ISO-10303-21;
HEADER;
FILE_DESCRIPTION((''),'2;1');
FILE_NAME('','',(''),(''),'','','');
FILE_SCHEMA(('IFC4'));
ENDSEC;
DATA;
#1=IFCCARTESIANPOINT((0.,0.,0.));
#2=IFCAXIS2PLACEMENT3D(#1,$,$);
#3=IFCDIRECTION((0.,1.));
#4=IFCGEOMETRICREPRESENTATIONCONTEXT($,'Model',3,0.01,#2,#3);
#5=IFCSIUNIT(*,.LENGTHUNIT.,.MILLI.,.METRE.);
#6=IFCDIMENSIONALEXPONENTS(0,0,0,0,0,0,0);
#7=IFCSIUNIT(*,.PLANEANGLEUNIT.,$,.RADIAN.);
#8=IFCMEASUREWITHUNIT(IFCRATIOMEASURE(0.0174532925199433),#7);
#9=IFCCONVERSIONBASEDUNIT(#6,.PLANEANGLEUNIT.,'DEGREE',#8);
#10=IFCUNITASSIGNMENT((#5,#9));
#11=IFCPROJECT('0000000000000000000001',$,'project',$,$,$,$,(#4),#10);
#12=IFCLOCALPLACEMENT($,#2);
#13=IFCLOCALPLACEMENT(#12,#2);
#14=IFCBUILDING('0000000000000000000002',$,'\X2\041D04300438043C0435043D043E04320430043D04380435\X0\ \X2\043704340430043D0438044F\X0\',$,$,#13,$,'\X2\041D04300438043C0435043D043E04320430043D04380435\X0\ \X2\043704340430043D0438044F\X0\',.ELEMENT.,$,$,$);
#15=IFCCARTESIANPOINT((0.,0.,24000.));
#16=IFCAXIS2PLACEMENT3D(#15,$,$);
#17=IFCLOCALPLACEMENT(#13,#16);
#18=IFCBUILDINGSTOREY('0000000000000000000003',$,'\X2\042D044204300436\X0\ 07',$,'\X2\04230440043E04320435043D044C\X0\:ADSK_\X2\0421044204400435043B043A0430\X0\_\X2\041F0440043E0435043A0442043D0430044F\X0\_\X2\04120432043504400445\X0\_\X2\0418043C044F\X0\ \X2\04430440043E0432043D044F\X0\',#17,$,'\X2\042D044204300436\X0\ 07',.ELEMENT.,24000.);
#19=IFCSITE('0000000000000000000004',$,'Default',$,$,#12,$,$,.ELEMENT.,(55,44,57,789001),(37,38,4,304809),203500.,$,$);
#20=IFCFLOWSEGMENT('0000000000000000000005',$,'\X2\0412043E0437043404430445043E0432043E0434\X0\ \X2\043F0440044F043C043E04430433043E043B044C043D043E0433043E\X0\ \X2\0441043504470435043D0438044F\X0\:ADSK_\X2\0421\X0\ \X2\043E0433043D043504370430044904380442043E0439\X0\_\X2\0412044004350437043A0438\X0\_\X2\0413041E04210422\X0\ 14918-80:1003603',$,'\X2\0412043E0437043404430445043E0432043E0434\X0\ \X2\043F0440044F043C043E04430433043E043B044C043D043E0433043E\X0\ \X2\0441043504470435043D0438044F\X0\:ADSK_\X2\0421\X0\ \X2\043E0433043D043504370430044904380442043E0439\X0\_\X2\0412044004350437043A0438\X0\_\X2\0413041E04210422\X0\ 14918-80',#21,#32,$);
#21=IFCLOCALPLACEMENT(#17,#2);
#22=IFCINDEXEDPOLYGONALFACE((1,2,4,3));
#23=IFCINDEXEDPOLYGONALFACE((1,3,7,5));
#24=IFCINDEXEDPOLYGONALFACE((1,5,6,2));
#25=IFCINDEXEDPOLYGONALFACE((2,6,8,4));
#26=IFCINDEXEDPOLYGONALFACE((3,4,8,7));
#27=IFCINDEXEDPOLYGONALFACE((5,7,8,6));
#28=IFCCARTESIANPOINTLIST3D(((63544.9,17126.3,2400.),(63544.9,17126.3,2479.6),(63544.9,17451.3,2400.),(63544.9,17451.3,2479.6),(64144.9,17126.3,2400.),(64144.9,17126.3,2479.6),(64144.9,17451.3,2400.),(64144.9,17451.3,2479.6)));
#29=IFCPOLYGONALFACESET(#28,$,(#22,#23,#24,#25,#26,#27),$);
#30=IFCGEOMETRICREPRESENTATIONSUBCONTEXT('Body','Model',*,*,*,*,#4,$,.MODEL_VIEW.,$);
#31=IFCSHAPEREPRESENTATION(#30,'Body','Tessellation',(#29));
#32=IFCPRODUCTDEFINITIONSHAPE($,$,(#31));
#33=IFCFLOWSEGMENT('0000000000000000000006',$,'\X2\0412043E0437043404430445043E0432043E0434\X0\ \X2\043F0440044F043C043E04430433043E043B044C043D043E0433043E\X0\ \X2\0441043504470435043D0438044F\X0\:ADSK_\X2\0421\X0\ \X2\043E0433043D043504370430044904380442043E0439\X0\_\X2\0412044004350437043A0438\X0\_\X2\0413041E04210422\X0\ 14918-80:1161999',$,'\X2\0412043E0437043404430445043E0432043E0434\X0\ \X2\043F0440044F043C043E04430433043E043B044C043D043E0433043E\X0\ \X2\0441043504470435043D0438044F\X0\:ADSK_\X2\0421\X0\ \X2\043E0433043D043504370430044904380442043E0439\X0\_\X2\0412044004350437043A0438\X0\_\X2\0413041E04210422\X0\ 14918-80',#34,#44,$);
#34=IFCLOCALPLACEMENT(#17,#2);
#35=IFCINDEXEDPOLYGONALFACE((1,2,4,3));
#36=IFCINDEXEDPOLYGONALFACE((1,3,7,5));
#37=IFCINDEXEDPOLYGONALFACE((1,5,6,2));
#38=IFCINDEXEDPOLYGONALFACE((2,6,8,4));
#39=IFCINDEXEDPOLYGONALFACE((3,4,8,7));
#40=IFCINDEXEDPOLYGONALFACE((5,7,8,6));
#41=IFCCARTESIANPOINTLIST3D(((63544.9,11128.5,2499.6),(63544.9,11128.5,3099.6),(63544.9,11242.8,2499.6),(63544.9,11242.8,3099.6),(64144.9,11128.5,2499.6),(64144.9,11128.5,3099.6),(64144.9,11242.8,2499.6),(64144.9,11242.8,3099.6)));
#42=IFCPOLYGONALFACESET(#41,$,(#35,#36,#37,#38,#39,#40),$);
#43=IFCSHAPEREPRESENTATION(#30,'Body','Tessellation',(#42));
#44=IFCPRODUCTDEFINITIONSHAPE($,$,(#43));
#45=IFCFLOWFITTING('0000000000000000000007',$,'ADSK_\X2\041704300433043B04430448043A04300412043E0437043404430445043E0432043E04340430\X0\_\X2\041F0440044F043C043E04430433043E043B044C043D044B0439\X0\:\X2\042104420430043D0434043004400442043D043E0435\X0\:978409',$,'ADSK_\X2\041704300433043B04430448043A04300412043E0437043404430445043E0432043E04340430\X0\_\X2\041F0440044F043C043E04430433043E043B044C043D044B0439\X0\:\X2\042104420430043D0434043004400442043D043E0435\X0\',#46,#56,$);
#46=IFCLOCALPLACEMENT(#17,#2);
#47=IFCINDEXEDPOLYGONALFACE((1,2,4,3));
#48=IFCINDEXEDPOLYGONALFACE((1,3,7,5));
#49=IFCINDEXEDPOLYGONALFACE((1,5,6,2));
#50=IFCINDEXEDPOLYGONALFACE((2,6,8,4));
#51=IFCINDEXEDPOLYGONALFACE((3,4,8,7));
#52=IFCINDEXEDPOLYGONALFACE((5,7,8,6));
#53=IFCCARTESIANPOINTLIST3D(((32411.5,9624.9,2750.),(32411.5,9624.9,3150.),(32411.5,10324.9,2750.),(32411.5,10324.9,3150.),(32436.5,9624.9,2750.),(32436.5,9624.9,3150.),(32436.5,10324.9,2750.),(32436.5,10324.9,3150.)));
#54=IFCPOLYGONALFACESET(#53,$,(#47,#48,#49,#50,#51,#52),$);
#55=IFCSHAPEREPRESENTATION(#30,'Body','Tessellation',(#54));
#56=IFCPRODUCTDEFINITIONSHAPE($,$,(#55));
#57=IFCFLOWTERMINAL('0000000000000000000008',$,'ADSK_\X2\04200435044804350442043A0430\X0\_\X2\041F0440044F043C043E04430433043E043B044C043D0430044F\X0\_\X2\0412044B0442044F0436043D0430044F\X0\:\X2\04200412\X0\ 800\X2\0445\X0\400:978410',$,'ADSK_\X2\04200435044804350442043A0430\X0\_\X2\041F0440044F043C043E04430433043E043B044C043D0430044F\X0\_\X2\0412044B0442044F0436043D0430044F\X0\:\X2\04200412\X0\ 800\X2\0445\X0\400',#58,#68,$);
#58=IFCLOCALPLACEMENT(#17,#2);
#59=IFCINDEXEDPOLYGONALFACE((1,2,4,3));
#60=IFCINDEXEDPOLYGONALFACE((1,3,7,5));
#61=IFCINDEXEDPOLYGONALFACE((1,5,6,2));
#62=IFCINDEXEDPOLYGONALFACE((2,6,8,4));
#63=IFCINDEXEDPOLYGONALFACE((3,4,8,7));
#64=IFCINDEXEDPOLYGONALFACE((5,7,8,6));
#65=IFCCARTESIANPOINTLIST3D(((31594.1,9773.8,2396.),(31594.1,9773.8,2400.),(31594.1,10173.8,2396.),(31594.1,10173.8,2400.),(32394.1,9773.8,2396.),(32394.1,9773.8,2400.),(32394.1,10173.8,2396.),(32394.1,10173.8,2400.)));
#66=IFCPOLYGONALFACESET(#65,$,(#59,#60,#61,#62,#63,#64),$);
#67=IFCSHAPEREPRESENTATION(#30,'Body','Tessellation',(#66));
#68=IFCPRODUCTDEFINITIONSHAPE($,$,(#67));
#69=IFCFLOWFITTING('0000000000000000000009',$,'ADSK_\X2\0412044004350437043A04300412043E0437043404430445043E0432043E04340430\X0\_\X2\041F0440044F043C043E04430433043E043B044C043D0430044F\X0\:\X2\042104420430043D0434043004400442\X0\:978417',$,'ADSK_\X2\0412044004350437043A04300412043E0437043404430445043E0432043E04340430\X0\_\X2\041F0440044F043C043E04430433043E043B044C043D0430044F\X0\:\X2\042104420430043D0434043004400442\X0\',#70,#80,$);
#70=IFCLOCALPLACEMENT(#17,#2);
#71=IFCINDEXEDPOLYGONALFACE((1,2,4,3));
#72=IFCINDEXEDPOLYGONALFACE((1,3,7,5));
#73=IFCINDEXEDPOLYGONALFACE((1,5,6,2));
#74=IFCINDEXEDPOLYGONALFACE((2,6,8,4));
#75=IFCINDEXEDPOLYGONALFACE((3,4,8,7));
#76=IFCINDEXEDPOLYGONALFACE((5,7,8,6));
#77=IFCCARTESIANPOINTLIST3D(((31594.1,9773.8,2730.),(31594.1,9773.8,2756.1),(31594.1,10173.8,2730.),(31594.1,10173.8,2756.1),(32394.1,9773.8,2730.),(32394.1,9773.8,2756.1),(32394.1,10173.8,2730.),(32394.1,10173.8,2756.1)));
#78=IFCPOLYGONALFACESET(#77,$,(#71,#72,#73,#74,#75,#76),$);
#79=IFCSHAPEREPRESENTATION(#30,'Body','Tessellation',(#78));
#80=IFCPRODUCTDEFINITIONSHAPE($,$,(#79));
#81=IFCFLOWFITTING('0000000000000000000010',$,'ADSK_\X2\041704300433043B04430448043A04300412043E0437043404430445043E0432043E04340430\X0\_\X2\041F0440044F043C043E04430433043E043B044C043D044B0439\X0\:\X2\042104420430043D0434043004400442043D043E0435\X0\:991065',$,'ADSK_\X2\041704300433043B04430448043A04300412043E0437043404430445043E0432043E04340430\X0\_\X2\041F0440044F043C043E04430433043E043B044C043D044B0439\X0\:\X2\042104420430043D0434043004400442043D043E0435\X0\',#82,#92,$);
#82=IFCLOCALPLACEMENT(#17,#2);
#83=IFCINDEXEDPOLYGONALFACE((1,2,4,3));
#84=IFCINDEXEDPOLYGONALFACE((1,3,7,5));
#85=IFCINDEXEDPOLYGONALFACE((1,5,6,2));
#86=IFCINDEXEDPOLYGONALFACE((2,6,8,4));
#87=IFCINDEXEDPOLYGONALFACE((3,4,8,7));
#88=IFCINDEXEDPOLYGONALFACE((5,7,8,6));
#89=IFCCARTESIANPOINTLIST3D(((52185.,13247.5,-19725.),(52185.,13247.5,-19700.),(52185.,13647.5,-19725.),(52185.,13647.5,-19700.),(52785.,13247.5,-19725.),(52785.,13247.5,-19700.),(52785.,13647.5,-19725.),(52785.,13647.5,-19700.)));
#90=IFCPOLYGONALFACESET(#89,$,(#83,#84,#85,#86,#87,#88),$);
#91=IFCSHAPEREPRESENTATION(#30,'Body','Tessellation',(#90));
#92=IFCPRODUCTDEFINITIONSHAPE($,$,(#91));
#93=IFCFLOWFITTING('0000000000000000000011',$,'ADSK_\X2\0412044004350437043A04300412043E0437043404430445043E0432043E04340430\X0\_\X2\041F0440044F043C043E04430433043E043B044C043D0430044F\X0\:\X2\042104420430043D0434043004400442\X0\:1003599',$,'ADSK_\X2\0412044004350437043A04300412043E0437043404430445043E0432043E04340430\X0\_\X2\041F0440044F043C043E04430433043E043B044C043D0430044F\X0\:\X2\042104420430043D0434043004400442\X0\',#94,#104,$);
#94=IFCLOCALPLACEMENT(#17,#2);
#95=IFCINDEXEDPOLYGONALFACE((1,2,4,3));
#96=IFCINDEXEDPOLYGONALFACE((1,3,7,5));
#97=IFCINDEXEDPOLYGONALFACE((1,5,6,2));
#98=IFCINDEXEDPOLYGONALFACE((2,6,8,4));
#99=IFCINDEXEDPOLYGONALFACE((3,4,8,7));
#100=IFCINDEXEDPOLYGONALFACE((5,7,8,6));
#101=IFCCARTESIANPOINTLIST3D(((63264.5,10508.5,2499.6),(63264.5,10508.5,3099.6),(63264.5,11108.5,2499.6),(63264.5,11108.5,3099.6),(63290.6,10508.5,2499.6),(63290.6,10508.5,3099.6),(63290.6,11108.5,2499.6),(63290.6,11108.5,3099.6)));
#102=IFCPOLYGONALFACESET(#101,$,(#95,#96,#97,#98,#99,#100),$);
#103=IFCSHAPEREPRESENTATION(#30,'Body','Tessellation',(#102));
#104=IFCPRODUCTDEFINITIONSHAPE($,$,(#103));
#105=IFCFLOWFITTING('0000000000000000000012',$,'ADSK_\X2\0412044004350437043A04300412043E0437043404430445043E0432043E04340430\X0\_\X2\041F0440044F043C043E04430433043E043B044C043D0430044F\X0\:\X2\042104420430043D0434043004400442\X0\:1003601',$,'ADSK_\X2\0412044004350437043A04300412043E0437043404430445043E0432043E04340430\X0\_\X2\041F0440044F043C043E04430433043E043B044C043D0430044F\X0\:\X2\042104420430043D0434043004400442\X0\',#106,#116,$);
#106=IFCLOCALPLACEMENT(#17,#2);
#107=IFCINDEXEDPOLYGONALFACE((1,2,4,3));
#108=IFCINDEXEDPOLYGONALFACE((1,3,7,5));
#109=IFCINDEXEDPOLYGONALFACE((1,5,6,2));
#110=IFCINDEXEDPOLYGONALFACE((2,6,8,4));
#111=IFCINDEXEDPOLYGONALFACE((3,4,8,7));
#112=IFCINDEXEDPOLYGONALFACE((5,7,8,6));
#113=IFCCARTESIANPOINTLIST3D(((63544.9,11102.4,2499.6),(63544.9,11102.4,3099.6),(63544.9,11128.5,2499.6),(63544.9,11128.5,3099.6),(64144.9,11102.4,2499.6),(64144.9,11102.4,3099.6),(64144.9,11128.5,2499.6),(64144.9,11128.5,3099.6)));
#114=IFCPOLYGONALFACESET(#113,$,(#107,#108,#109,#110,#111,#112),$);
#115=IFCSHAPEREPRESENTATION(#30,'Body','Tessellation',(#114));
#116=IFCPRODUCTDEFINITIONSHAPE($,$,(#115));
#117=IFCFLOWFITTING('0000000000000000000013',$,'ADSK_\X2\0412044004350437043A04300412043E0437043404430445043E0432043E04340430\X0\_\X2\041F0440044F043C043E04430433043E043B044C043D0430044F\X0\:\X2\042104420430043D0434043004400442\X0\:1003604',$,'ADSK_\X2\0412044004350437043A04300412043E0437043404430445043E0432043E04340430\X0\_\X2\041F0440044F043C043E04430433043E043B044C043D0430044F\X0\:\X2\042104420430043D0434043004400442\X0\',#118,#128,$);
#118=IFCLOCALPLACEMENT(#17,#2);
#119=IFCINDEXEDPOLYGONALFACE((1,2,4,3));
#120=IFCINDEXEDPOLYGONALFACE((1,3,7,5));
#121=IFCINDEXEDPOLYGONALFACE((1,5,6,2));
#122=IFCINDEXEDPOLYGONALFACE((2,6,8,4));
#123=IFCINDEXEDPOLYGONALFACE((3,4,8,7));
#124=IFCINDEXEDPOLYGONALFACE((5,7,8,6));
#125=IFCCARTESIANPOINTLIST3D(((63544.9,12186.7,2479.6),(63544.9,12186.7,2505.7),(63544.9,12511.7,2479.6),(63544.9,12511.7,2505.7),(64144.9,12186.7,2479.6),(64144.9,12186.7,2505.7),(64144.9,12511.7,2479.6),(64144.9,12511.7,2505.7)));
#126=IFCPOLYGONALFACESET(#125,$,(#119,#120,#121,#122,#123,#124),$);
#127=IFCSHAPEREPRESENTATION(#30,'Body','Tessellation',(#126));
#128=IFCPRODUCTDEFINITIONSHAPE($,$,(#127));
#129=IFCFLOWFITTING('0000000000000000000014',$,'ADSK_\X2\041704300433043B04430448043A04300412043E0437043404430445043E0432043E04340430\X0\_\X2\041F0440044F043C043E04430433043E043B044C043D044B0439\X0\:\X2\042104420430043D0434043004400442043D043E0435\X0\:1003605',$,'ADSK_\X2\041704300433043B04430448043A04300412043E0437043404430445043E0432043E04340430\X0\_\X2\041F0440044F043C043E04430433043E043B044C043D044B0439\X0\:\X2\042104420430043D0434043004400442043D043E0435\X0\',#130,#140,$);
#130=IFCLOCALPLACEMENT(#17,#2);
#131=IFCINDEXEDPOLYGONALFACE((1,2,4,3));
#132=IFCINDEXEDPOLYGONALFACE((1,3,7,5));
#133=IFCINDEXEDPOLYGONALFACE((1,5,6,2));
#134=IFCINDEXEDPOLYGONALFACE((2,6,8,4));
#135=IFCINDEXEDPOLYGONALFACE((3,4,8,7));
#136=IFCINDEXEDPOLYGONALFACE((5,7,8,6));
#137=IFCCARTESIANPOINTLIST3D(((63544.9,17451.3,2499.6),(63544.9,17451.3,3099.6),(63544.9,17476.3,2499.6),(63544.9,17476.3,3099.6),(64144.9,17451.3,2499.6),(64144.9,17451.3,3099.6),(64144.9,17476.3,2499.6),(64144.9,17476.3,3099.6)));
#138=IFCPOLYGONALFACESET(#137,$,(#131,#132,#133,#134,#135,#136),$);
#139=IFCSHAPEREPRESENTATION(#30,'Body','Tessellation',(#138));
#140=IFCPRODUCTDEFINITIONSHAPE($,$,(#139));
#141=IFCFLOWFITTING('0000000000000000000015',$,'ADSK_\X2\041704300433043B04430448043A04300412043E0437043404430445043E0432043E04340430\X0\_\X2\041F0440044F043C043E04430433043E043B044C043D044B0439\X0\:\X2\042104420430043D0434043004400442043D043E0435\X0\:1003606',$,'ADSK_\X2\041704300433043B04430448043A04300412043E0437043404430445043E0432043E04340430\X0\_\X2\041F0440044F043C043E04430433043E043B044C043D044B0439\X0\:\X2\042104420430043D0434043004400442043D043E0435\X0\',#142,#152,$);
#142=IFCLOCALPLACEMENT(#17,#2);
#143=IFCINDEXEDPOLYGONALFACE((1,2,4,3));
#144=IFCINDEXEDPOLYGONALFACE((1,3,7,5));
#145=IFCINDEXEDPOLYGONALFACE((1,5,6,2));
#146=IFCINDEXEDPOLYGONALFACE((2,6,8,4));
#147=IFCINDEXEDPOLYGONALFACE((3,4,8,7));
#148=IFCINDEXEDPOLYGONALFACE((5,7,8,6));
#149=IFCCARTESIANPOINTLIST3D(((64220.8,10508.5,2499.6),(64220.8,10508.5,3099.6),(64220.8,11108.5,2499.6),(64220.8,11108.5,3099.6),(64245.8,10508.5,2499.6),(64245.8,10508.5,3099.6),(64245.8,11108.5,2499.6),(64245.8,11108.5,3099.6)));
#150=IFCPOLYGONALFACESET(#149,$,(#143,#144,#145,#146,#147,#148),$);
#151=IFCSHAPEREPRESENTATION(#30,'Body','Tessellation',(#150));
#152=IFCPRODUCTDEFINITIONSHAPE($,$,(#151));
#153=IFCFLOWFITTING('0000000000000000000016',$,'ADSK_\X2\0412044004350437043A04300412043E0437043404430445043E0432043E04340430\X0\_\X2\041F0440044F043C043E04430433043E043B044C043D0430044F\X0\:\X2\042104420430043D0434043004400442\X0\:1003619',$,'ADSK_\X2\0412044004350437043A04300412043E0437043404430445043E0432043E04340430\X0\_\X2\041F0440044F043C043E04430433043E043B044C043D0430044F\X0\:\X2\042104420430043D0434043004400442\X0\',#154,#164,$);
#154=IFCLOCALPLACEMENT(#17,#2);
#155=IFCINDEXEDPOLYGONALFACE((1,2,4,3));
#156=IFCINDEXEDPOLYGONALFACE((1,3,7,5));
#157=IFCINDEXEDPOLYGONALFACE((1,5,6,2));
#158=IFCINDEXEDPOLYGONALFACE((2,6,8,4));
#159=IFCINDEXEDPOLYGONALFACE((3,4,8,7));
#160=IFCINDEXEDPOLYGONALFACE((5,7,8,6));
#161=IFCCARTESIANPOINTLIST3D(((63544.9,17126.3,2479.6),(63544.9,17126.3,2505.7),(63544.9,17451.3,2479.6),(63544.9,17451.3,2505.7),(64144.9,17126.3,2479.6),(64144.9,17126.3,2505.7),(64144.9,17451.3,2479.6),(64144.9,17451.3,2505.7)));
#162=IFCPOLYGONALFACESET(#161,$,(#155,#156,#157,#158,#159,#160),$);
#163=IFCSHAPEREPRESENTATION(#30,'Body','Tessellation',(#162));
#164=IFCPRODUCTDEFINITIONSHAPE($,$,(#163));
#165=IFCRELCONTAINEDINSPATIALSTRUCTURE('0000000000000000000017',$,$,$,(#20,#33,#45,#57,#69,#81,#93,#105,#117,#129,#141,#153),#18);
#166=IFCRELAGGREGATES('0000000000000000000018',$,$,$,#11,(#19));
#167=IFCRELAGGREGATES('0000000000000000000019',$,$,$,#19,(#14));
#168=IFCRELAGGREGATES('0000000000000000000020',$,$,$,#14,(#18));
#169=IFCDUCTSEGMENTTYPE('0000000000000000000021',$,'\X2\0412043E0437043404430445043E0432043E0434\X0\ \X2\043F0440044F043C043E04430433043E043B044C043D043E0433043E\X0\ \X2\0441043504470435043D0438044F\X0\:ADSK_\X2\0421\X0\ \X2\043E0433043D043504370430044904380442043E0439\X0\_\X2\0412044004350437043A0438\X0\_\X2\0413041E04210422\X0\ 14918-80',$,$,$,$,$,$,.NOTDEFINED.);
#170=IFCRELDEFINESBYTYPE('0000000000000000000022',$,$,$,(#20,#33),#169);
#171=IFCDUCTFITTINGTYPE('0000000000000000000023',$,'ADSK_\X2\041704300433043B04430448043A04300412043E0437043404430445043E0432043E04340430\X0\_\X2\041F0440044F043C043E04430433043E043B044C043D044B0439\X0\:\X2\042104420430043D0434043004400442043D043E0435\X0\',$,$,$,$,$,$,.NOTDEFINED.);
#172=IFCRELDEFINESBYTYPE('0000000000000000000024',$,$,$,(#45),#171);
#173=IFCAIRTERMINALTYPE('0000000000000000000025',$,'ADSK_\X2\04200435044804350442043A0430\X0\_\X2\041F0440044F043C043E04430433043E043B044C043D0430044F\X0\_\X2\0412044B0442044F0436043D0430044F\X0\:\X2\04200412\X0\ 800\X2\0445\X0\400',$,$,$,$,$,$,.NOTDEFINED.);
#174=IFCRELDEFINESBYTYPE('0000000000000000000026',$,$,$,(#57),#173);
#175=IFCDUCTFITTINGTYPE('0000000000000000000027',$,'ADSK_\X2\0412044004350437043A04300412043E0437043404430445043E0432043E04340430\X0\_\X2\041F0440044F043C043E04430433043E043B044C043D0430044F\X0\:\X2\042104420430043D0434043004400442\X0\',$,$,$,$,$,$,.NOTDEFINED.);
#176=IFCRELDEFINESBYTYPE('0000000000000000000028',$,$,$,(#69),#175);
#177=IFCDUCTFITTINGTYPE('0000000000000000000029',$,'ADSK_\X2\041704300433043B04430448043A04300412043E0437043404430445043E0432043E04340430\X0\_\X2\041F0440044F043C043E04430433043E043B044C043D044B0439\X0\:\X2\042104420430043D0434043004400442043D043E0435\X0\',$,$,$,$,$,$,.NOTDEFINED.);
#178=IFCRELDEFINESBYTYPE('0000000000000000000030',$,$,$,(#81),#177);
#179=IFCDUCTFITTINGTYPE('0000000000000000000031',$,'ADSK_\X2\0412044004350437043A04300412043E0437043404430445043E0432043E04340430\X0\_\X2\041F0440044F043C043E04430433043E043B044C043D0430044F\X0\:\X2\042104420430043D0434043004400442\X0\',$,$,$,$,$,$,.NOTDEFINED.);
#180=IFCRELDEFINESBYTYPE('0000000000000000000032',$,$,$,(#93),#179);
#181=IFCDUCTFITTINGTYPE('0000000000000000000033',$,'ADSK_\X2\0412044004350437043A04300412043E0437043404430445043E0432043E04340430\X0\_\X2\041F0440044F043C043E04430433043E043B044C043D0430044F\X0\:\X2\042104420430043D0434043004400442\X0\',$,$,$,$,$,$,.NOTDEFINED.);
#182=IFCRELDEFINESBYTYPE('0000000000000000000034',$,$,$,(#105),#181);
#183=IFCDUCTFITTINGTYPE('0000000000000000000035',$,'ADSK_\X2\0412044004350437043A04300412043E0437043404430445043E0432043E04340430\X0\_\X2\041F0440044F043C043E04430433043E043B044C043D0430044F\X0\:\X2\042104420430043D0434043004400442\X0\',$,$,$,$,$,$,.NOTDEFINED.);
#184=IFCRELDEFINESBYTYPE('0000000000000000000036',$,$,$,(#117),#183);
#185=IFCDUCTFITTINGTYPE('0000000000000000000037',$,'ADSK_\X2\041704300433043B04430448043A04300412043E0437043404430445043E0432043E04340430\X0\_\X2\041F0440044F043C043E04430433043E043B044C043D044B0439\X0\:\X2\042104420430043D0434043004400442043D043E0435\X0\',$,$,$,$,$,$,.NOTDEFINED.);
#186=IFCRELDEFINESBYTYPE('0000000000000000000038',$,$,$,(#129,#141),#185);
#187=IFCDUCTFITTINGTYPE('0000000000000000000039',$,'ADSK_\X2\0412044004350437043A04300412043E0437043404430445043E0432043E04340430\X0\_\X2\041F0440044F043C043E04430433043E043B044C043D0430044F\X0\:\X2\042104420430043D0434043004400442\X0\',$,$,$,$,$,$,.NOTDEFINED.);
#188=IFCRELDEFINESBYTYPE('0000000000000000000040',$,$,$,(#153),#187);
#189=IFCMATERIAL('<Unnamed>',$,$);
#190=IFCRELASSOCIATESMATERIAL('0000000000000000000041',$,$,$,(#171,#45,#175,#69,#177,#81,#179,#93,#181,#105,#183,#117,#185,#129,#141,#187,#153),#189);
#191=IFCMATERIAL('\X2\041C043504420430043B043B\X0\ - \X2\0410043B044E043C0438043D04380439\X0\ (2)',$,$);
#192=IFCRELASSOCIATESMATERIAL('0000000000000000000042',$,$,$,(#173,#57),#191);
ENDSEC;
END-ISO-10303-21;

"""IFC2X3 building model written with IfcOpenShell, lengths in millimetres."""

from ifc_helpers import new_model, entity, si_unit, converted_unit, direction, frame, frame_2d, origin, origin_2d_with_axis, place, context, subcontext, project, spatial, rectangle, extrude, source, transform, mapped, material, type_object, type_shapes, element, save


model = new_model("IFC2X3")

# Units and contexts
model_context = context("Model", 3, precision=0.01, world=origin(), true_north=direction((0.0, 1.0)))
body_context = subcontext(model_context, "Body", "Model", "MODEL_VIEW")
ifc_project = project(units=[si_unit("LENGTHUNIT", "METRE", prefix="MILLI"), converted_unit("PLANEANGLEUNIT", "DEGREE", entity("IfcRatioMeasure", 0.0174532925199433), si_unit("PLANEANGLEUNIT", "RADIAN"), dimensions=[0, 0, 0, 0, 0, 0, 0])], contexts=[model_context])

# Site, building, storey
site_placement = place(None, frame((0.0, 0.0, 0.0)))
site = spatial("IfcSite", under=ifc_project, at=site_placement, Name="Default", CompositionType="ELEMENT", RefLatitude=(55, 44, 57, 789001), RefLongitude=(37, 38, 4, 304809), RefElevation=203500.0)
building_placement = place(site_placement, origin())
building = spatial("IfcBuilding", under=site, at=building_placement, Name="Наименование здания", LongName="Наименование здания", CompositionType="ELEMENT")
storey_placement = place(building_placement, frame((0.0, 0.0, 24000.0)))
storey = spatial("IfcBuildingStorey", under=building, at=storey_placement, Name="Этаж 07", ObjectType="Уровень:ADSK_Стрелка_Проектная_Вверх_Имя уровня", LongName="Этаж 07", CompositionType="ELEMENT", Elevation=24000.0)

# Flow segments
duct_segment_type_1 = type_object("IfcDuctSegmentType", Name="Воздуховод прямоугольного сечения:ADSK_С огнезащитой_Врезки_ГОСТ 14918-80", PredefinedType="NOTDEFINED")
flow_segment_1_placement = place(storey_placement, frame((63544.9, 17126.3, 2400.0)))
element("IfcFlowSegment", 1, at=flow_segment_1_placement, inside=storey, type_object=duct_segment_type_1, Name="Воздуховод прямоугольного сечения:ADSK_С огнезащитой_Врезки_ГОСТ 14918-80:1003603", ObjectType="Воздуховод прямоугольного сечения:ADSK_С огнезащитой_Врезки_ГОСТ 14918-80", context=body_context, shape_type="SweptSolid", body=[
    extrude(rectangle(XDim=600.0, YDim=325.0, at=frame_2d((0.0, 0.0), x_axis=(1.0, 0.0))), frame((300.0, 162.5, 0.0), z_axis=(0.0, 0.0, 1.0), x_axis=(-1.0, 0.0, 0.0)), (0.0, 0.0, 1.0), 79.6),
])
flow_segment_2_placement = place(storey_placement, frame((63544.9, 11128.5, 2499.6)))
element("IfcFlowSegment", 2, at=flow_segment_2_placement, inside=storey, type_object=duct_segment_type_1, Name="Воздуховод прямоугольного сечения:ADSK_С огнезащитой_Врезки_ГОСТ 14918-80:1161999", ObjectType="Воздуховод прямоугольного сечения:ADSK_С огнезащитой_Врезки_ГОСТ 14918-80", context=body_context, shape_type="SweptSolid", body=[
    extrude(rectangle(XDim=114.3, YDim=600.0, at=origin_2d_with_axis()), frame((300.0, 57.1, 0.0), z_axis=(0.0, 0.0, 1.0), x_axis=(0.0, 1.0, 0.0)), (0.0, 0.0, 1.0), 600.0),
])

# Flow fitting
ifc_material_1 = material(Name="<Unnamed>")
duct_fitting_type_1 = type_object("IfcDuctFittingType", Name="ADSK_ЗаглушкаВоздуховода_Прямоугольный:Стандартное", PredefinedType="NOTDEFINED", material=ifc_material_1)
shared_shape_1 = source(origin(), body_context, "Body", "SweptSolid", [
    extrude(rectangle(XDim=25.0, YDim=700.0, at=frame_2d((0.0, 0.0), x_axis=(1.0, 0.0))), frame((12.5, 0.0, -200.0)), (0.0, 0.0, 1.0), 400.0),
])
type_shapes(duct_fitting_type_1, [shared_shape_1])
flow_fitting_1_placement = place(storey_placement, frame((32411.5, 9974.9, 2950.0)))
element("IfcFlowFitting", 3, at=flow_fitting_1_placement, inside=storey, type_object=duct_fitting_type_1, material=ifc_material_1, Name="ADSK_ЗаглушкаВоздуховода_Прямоугольный:Стандартное:978409", ObjectType="ADSK_ЗаглушкаВоздуховода_Прямоугольный:Стандартное", context=body_context, shape_type="MappedRepresentation", body=[
    mapped(shared_shape_1, transform((0.0, 0.0, 0.0), scale=1.0)),
])

# Flow terminal
ifc_material_2 = material(Name="Металл - Алюминий (2)")
air_terminal_type_1 = type_object("IfcAirTerminalType", Name="ADSK_Решетка_Прямоугольная_Вытяжная:РВ 800х400", PredefinedType="NOTDEFINED", material=ifc_material_2)
shared_shape_2 = source(origin(), body_context, "Body", "SweptSolid", [
    extrude(rectangle(XDim=4.0, YDim=800.0, at=origin_2d_with_axis()), frame((0.0, -2.0, -200.0), z_axis=(0.0, 0.0, 1.0), x_axis=(0.0, 1.0, 0.0)), (0.0, 0.0, 1.0), 400.0),
])
type_shapes(air_terminal_type_1, [shared_shape_2])
flow_terminal_1_placement = place(storey_placement, frame((31994.1, 9973.8, 2400.0), z_axis=(0.0, 1.0, 0.0), x_axis=(-1.0, 0.0, 0.0)))
element("IfcFlowTerminal", 4, at=flow_terminal_1_placement, inside=storey, type_object=air_terminal_type_1, material=ifc_material_2, Name="ADSK_Решетка_Прямоугольная_Вытяжная:РВ 800х400:978410", ObjectType="ADSK_Решетка_Прямоугольная_Вытяжная:РВ 800х400", context=body_context, shape_type="MappedRepresentation", body=[
    mapped(shared_shape_2, transform((0.0, 0.0, 0.0), scale=1.0)),
])

# Flow fittings
duct_fitting_type_2 = type_object("IfcDuctFittingType", Name="ADSK_ВрезкаВоздуховода_Прямоугольная:Стандарт", PredefinedType="NOTDEFINED", material=ifc_material_1)
shared_shape_3 = source(origin(), body_context, "Body", "SweptSolid", [
    extrude(rectangle(XDim=26.1, YDim=800.0, at=frame_2d((0.0, 0.0), x_axis=(1.0, 0.0))), frame((7.0, 0.0, -200.0)), (0.0, 0.0, 1.0), 400.0),
])
type_shapes(duct_fitting_type_2, [shared_shape_3])
flow_fitting_2_placement = place(storey_placement, frame((31994.1, 9973.8, 2750.0), z_axis=(0.0, 1.0, 0.0), x_axis=(0.0, 0.0, -1.0)))
element("IfcFlowFitting", 5, at=flow_fitting_2_placement, inside=storey, type_object=duct_fitting_type_2, material=ifc_material_1, Name="ADSK_ВрезкаВоздуховода_Прямоугольная:Стандарт:978417", ObjectType="ADSK_ВрезкаВоздуховода_Прямоугольная:Стандарт", context=body_context, shape_type="MappedRepresentation", body=[
    mapped(shared_shape_3, transform((0.0, 0.0, 0.0), scale=1.0)),
])
duct_fitting_type_3 = type_object("IfcDuctFittingType", Name="ADSK_ЗаглушкаВоздуховода_Прямоугольный:Стандартное", PredefinedType="NOTDEFINED", material=ifc_material_1)
shared_shape_4 = source(origin(), body_context, "Body", "SweptSolid", [
    extrude(rectangle(XDim=25.0, YDim=600.0, at=frame_2d((0.0, 0.0), x_axis=(1.0, 0.0))), frame((12.5, 0.0, -200.0)), (0.0, 0.0, 1.0), 400.0),
])
type_shapes(duct_fitting_type_3, [shared_shape_4])
flow_fitting_3_placement = place(storey_placement, frame((52485.0, 13447.5, -19700.0), z_axis=(0.0, -1.0, 0.0), x_axis=(0.0, 0.0, -1.0)))
element("IfcFlowFitting", 6, at=flow_fitting_3_placement, inside=storey, type_object=duct_fitting_type_3, material=ifc_material_1, Name="ADSK_ЗаглушкаВоздуховода_Прямоугольный:Стандартное:991065", ObjectType="ADSK_ЗаглушкаВоздуховода_Прямоугольный:Стандартное", context=body_context, shape_type="MappedRepresentation", body=[
    mapped(shared_shape_4, transform((0.0, 0.0, 0.0), scale=1.0)),
])
duct_fitting_type_4 = type_object("IfcDuctFittingType", Name="ADSK_ВрезкаВоздуховода_Прямоугольная:Стандарт", PredefinedType="NOTDEFINED", material=ifc_material_1)
shared_shape_5 = source(origin(), body_context, "Body", "SweptSolid", [
    extrude(rectangle(XDim=26.1, YDim=600.0, at=frame_2d((0.0, 0.0), x_axis=(1.0, 0.0))), frame((7.0, 0.0, -300.0)), (0.0, 0.0, 1.0), 600.0),
])
type_shapes(duct_fitting_type_4, [shared_shape_5])
flow_fitting_4_placement = place(storey_placement, frame((63270.6, 10808.5, 2799.6), z_axis=(0.0, -1.0, 0.0), x_axis=(1.0, 0.0, 0.0)))
element("IfcFlowFitting", 7, at=flow_fitting_4_placement, inside=storey, type_object=duct_fitting_type_4, material=ifc_material_1, Name="ADSK_ВрезкаВоздуховода_Прямоугольная:Стандарт:1003599", ObjectType="ADSK_ВрезкаВоздуховода_Прямоугольная:Стандарт", context=body_context, shape_type="MappedRepresentation", body=[
    mapped(shared_shape_5, transform((0.0, 0.0, 0.0), scale=1.0)),
])
duct_fitting_type_5 = type_object("IfcDuctFittingType", Name="ADSK_ВрезкаВоздуховода_Прямоугольная:Стандарт", PredefinedType="NOTDEFINED", material=ifc_material_1)
shared_shape_6 = source(origin(), body_context, "Body", "SweptSolid", [
    extrude(rectangle(XDim=600.0, YDim=26.1, at=origin_2d_with_axis()), frame((7.0, 0.0, -300.0), z_axis=(0.0, 0.0, 1.0), x_axis=(0.0, -1.0, 0.0)), (0.0, 0.0, 1.0), 600.0),
])
type_shapes(duct_fitting_type_5, [shared_shape_6])
flow_fitting_5_placement = place(storey_placement, frame((63844.9, 11108.5, 2799.6), z_axis=(0.0, 0.0, -1.0), x_axis=(0.0, 1.0, 0.0)))
element("IfcFlowFitting", 8, at=flow_fitting_5_placement, inside=storey, type_object=duct_fitting_type_5, material=ifc_material_1, Name="ADSK_ВрезкаВоздуховода_Прямоугольная:Стандарт:1003601", ObjectType="ADSK_ВрезкаВоздуховода_Прямоугольная:Стандарт", context=body_context, shape_type="MappedRepresentation", body=[
    mapped(shared_shape_6, transform((0.0, 0.0, 0.0), scale=1.0)),
])
duct_fitting_type_6 = type_object("IfcDuctFittingType", Name="ADSK_ВрезкаВоздуховода_Прямоугольная:Стандарт", PredefinedType="NOTDEFINED", material=ifc_material_1)
shared_shape_7 = source(origin(), body_context, "Body", "SweptSolid", [
    extrude(rectangle(XDim=26.1, YDim=600.0, at=frame_2d((0.0, 0.0), x_axis=(1.0, 0.0))), frame((7.0, 0.0, -162.5)), (0.0, 0.0, 1.0), 325.0),
])
type_shapes(duct_fitting_type_6, [shared_shape_7])
flow_fitting_6_placement = place(storey_placement, frame((63844.9, 12349.2, 2499.6), z_axis=(0.0, 1.0, 0.0), x_axis=(0.0, 0.0, -1.0)))
element("IfcFlowFitting", 9, at=flow_fitting_6_placement, inside=storey, type_object=duct_fitting_type_6, material=ifc_material_1, Name="ADSK_ВрезкаВоздуховода_Прямоугольная:Стандарт:1003604", ObjectType="ADSK_ВрезкаВоздуховода_Прямоугольная:Стандарт", context=body_context, shape_type="MappedRepresentation", body=[
    mapped(shared_shape_7, transform((0.0, 0.0, 0.0), scale=1.0)),
])
duct_fitting_type_7 = type_object("IfcDuctFittingType", Name="ADSK_ЗаглушкаВоздуховода_Прямоугольный:Стандартное", PredefinedType="NOTDEFINED", material=ifc_material_1)
shared_shape_8 = source(origin(), body_context, "Body", "SweptSolid", [
    extrude(rectangle(XDim=25.0, YDim=600.0, at=frame_2d((0.0, 0.0), x_axis=(1.0, 0.0))), frame((12.5, 0.0, -300.0)), (0.0, 0.0, 1.0), 600.0),
])
type_shapes(duct_fitting_type_7, [shared_shape_8])
flow_fitting_7_placement = place(storey_placement, frame((63844.9, 17451.3, 2799.6), z_axis=(0.0, 0.0, 1.0), x_axis=(0.0, 1.0, 0.0)))
element("IfcFlowFitting", 10, at=flow_fitting_7_placement, inside=storey, type_object=duct_fitting_type_7, material=ifc_material_1, Name="ADSK_ЗаглушкаВоздуховода_Прямоугольный:Стандартное:1003605", ObjectType="ADSK_ЗаглушкаВоздуховода_Прямоугольный:Стандартное", context=body_context, shape_type="MappedRepresentation", body=[
    mapped(shared_shape_8, transform((0.0, 0.0, 0.0), scale=1.0)),
])
flow_fitting_8_placement = place(storey_placement, frame((64220.8, 10808.5, 2799.6)))
element("IfcFlowFitting", 11, at=flow_fitting_8_placement, inside=storey, type_object=duct_fitting_type_7, material=ifc_material_1, Name="ADSK_ЗаглушкаВоздуховода_Прямоугольный:Стандартное:1003606", ObjectType="ADSK_ЗаглушкаВоздуховода_Прямоугольный:Стандартное", context=body_context, shape_type="MappedRepresentation", body=[
    mapped(shared_shape_8, transform((0.0, 0.0, 0.0), scale=1.0)),
])
duct_fitting_type_8 = type_object("IfcDuctFittingType", Name="ADSK_ВрезкаВоздуховода_Прямоугольная:Стандарт", PredefinedType="NOTDEFINED", material=ifc_material_1)
shared_shape_9 = source(origin(), body_context, "Body", "SweptSolid", [
    extrude(rectangle(XDim=600.0, YDim=26.1, at=origin_2d_with_axis()), frame((7.0, 0.0, -162.5), z_axis=(0.0, 0.0, 1.0), x_axis=(0.0, -1.0, 0.0)), (0.0, 0.0, 1.0), 325.0),
])
type_shapes(duct_fitting_type_8, [shared_shape_9])
flow_fitting_9_placement = place(storey_placement, frame((63844.9, 17288.8, 2499.6), z_axis=(0.0, -1.0, 0.0), x_axis=(0.0, 0.0, -1.0)))
element("IfcFlowFitting", 12, at=flow_fitting_9_placement, inside=storey, type_object=duct_fitting_type_8, material=ifc_material_1, Name="ADSK_ВрезкаВоздуховода_Прямоугольная:Стандарт:1003619", ObjectType="ADSK_ВрезкаВоздуховода_Прямоугольная:Стандарт", context=body_context, shape_type="MappedRepresentation", body=[
    mapped(shared_shape_9, transform((0.0, 0.0, 0.0), scale=1.0)),
])

save(model, "model.ifc")
